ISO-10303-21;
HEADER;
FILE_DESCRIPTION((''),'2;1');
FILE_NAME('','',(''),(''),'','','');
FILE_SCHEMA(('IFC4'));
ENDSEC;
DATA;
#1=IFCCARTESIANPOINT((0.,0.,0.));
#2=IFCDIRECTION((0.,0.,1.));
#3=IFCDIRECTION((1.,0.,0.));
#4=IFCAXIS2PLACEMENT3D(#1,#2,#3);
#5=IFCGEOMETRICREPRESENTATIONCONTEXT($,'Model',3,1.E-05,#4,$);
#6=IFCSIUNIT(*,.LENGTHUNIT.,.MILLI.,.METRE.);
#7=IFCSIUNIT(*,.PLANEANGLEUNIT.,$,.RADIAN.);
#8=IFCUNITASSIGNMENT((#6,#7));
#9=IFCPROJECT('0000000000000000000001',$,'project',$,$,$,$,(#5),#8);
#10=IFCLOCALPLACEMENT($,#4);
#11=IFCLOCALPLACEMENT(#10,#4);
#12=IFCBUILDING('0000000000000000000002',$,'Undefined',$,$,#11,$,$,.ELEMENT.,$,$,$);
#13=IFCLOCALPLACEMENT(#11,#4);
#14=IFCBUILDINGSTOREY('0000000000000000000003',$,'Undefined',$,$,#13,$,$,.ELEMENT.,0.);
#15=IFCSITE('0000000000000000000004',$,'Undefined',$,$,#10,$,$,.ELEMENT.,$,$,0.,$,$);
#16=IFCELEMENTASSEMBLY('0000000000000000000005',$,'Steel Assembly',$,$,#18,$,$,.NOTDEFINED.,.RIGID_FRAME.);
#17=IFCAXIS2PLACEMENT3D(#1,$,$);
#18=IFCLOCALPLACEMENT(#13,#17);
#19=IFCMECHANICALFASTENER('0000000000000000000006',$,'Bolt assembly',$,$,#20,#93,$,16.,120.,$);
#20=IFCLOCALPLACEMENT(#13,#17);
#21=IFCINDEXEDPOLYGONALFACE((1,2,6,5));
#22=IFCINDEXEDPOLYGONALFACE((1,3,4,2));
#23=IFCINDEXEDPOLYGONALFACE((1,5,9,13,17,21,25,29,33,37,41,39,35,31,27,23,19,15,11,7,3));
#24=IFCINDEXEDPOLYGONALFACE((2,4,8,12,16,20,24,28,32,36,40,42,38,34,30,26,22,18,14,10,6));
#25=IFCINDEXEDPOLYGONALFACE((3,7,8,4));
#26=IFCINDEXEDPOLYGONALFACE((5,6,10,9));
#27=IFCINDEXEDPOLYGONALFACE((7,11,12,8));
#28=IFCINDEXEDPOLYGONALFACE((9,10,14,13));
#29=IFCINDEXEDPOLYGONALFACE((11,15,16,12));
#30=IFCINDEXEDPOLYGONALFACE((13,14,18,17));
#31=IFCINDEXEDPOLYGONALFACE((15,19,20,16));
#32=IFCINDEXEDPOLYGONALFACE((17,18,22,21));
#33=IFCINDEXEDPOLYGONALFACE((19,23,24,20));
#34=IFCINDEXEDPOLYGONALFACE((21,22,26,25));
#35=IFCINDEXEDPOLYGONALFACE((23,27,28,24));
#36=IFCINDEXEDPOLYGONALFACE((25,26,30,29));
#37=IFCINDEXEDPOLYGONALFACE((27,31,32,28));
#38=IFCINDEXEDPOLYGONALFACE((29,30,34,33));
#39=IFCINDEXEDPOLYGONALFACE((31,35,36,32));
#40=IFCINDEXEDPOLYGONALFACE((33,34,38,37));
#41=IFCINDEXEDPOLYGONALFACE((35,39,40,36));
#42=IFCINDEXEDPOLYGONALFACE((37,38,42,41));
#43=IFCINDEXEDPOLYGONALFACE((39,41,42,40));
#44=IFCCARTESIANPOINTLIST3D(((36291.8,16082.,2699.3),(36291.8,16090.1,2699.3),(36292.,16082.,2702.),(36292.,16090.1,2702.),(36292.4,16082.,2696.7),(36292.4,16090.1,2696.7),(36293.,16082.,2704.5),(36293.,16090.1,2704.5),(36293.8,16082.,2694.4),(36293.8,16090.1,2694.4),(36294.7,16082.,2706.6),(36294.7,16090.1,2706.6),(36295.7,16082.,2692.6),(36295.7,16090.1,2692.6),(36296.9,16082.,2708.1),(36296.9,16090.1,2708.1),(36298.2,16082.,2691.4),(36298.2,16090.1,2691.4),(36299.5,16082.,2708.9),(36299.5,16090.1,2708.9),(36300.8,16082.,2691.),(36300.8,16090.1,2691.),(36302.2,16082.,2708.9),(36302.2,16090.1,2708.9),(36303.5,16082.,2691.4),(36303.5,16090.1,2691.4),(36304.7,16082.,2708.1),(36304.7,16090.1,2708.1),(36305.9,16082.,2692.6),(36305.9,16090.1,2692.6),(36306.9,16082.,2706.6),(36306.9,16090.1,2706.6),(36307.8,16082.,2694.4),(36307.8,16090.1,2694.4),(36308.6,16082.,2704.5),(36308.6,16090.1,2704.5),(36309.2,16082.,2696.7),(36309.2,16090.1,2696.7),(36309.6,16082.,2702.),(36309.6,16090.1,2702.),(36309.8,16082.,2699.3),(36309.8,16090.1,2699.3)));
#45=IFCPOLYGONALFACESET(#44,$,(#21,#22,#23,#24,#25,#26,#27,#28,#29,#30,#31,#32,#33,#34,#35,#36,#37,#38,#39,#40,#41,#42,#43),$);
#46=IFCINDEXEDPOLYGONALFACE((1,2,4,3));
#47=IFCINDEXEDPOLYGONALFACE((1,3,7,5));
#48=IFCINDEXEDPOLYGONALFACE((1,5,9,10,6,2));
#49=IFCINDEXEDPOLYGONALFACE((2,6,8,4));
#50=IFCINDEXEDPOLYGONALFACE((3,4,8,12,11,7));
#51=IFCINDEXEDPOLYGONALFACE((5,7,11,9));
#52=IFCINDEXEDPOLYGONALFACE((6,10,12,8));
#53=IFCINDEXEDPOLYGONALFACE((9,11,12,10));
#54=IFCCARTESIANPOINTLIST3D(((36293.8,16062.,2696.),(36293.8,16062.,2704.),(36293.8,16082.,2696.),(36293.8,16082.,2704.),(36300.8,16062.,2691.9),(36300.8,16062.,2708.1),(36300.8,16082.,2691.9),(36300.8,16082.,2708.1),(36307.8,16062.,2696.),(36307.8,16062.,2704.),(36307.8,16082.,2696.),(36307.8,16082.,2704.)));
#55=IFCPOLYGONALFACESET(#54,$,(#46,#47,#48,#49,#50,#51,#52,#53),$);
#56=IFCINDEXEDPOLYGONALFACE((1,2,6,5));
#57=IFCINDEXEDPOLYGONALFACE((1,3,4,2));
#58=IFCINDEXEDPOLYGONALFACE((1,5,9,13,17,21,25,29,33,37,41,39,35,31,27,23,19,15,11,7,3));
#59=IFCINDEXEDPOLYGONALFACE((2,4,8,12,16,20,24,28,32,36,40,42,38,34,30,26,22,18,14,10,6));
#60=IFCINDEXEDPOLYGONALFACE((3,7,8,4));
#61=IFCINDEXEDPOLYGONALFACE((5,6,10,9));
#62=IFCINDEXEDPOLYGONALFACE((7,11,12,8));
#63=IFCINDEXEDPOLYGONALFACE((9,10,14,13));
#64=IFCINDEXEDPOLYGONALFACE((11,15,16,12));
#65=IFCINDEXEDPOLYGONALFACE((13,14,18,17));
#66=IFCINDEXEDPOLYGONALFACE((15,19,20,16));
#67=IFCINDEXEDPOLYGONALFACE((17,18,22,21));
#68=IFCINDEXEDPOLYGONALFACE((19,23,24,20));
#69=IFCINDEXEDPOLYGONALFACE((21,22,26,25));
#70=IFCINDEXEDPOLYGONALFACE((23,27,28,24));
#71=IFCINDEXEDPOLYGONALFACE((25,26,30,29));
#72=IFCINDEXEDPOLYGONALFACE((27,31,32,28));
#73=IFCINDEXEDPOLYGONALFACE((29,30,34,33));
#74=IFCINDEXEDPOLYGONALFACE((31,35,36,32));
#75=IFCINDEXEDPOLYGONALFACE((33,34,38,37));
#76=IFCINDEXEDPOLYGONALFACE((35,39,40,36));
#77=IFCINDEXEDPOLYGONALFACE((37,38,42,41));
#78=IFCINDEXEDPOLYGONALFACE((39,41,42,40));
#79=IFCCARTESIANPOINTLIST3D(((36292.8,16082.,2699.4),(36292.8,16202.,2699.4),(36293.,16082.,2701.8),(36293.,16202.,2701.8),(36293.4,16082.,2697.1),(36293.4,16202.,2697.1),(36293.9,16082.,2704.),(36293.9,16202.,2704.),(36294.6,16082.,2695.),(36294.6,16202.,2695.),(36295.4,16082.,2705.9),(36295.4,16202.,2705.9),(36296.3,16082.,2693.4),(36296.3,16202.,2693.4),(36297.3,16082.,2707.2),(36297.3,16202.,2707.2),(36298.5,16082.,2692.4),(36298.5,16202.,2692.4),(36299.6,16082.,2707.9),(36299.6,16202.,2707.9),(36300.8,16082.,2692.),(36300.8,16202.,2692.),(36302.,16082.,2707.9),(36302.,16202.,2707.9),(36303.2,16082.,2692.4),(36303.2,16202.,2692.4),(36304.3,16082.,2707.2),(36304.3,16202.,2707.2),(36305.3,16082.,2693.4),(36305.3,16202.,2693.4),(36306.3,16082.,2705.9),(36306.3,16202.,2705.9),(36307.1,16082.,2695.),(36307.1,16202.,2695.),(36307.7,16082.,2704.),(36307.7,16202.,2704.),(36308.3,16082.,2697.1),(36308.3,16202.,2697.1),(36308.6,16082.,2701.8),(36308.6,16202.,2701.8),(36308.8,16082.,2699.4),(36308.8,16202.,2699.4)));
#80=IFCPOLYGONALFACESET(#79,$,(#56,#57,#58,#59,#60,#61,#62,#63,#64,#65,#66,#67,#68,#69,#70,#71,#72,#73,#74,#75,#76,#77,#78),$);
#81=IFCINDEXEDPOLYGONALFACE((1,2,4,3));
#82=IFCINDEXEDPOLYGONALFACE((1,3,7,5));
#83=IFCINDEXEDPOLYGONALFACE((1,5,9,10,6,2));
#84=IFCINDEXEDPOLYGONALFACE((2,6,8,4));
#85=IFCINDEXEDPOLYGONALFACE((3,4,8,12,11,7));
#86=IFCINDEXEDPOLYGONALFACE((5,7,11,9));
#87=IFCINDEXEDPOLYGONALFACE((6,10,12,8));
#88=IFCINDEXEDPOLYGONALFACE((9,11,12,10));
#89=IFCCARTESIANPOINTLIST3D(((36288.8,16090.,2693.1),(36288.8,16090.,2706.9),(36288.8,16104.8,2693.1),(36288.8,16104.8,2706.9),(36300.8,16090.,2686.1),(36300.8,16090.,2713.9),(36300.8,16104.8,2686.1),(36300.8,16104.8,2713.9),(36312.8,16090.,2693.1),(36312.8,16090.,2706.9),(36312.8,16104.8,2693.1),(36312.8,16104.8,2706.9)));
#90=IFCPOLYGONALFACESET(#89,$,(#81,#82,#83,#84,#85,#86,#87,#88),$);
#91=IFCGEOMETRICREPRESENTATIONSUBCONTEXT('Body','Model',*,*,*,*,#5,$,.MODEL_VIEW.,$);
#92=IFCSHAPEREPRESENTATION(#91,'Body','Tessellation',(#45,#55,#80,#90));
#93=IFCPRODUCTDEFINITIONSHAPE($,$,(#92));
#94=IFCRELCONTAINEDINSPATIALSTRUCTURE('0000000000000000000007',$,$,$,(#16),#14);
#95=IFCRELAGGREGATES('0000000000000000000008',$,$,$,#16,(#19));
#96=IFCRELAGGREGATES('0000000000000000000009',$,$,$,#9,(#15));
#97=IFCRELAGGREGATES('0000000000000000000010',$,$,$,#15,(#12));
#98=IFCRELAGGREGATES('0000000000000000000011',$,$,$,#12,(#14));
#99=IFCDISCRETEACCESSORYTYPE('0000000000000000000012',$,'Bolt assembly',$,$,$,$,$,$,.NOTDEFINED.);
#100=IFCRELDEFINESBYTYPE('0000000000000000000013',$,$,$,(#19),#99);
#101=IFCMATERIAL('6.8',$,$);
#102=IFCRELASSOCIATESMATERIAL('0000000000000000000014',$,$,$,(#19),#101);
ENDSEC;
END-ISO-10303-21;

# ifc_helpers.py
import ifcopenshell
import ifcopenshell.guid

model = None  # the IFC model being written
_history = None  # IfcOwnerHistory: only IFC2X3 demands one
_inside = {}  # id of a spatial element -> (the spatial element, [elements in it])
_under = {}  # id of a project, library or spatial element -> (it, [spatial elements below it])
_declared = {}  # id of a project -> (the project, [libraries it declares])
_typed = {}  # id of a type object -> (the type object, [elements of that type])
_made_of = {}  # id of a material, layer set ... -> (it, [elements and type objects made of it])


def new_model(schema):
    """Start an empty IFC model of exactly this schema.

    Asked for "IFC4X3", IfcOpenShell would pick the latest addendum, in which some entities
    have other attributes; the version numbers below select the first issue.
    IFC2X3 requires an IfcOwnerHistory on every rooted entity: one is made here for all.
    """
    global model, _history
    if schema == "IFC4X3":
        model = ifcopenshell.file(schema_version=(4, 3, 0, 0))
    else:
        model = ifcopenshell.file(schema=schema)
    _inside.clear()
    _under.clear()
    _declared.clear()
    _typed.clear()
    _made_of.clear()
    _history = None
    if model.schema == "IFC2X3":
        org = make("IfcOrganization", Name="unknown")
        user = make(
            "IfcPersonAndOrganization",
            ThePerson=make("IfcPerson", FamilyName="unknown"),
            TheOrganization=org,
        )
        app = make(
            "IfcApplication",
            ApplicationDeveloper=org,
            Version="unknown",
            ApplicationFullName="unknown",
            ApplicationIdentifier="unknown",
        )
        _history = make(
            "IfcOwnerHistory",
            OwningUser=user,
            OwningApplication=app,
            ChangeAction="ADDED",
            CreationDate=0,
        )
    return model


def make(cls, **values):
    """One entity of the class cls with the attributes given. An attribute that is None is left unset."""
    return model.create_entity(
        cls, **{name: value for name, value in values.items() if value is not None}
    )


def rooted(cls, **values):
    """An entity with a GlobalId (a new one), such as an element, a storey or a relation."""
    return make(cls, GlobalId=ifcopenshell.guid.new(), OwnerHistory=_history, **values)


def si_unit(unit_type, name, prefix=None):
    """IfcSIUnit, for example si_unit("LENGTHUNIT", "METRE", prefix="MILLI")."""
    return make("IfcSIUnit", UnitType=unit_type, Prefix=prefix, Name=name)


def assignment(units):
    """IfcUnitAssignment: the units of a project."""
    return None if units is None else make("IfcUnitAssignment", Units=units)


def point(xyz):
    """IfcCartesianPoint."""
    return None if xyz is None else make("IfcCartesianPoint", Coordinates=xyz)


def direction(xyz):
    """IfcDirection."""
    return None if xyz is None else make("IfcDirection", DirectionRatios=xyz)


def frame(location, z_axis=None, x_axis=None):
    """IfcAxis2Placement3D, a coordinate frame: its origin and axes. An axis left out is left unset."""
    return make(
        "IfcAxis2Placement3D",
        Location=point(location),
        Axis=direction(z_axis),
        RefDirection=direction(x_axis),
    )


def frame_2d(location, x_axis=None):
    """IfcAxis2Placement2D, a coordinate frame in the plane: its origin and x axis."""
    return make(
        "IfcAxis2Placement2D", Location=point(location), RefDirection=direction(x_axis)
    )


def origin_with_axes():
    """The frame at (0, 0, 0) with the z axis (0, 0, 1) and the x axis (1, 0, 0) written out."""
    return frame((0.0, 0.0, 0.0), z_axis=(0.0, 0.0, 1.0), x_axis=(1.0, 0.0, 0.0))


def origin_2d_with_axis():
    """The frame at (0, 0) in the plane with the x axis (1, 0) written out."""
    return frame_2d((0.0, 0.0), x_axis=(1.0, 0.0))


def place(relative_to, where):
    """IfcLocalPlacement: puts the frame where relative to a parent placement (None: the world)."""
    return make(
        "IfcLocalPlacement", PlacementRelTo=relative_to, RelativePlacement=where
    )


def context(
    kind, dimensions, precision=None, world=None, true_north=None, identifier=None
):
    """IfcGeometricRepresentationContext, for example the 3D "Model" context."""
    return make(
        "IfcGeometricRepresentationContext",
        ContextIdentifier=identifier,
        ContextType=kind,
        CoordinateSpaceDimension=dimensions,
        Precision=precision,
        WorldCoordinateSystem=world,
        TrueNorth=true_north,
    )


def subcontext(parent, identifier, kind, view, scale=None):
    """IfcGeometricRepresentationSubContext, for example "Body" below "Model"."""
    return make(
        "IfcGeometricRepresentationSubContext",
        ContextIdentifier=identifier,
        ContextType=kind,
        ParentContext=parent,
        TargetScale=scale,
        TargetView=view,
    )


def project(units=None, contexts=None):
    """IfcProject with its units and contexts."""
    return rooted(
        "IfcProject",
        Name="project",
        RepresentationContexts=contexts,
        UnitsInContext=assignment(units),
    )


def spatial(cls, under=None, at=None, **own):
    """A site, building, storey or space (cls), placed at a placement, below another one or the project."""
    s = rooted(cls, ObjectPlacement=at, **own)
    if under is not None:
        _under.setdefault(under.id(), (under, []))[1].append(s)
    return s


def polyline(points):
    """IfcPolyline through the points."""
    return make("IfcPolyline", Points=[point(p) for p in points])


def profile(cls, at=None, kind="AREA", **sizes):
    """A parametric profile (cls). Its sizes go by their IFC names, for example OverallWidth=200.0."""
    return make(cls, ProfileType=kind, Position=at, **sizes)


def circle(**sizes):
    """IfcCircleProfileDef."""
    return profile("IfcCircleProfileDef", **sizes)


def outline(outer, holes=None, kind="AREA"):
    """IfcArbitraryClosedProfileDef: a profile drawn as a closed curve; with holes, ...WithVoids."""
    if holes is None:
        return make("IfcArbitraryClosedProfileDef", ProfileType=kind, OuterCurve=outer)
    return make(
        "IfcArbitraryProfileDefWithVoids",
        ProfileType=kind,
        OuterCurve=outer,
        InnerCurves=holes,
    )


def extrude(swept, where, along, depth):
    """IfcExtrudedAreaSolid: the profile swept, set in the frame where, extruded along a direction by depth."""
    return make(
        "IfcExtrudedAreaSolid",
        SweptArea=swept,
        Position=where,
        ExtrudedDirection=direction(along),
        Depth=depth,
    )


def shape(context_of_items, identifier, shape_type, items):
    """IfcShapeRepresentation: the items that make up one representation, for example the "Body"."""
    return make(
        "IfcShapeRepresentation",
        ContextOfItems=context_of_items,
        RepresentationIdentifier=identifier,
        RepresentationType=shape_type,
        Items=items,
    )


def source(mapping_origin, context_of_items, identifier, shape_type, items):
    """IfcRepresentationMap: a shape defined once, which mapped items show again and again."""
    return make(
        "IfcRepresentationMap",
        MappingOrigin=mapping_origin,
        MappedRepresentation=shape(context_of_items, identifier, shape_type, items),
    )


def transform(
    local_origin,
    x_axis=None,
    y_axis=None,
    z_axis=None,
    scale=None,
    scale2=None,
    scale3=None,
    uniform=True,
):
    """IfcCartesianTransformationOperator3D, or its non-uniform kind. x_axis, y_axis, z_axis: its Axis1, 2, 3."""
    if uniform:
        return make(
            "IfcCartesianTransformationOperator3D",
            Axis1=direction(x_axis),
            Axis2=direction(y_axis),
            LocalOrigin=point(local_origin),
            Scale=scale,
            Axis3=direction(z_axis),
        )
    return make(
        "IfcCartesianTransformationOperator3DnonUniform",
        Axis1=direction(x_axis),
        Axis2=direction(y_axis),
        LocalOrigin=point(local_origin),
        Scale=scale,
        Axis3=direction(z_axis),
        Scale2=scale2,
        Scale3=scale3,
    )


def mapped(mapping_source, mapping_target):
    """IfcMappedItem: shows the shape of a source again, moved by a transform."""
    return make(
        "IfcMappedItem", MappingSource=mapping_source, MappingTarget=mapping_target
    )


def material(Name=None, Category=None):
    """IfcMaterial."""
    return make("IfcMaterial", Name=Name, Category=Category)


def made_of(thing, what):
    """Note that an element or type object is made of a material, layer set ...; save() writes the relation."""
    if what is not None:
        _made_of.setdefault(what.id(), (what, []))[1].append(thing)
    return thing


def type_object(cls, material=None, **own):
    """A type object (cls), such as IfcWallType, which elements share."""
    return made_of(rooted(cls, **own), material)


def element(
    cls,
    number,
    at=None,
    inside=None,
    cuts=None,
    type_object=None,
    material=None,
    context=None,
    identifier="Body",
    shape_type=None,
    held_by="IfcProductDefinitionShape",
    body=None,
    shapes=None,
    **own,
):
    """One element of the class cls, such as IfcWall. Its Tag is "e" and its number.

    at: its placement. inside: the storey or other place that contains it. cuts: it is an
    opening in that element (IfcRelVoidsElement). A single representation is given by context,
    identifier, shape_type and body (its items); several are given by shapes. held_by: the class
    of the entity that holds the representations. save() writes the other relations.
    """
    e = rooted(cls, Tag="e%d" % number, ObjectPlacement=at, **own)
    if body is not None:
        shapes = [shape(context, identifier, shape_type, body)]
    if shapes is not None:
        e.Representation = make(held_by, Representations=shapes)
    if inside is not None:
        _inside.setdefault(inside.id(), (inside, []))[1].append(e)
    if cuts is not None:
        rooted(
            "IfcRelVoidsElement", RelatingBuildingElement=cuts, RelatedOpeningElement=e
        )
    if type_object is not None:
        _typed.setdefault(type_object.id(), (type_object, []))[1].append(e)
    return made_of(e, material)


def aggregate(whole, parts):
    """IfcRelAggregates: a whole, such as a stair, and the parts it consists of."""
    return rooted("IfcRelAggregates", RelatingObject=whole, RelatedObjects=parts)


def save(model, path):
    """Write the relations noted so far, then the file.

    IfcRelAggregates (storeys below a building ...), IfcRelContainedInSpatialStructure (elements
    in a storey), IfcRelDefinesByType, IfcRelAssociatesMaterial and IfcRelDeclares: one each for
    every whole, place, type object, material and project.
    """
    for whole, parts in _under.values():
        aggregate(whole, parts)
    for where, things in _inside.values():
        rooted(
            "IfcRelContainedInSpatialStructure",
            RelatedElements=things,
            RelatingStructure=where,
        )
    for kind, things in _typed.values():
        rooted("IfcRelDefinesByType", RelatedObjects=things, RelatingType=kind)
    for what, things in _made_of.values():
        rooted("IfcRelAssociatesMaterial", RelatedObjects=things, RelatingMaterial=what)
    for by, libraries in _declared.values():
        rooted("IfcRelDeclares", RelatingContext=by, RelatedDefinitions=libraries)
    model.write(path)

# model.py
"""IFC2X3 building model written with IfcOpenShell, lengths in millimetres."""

from ifc_helpers import new_model, si_unit, frame, origin_with_axes, origin_2d_with_axis, place, context, subcontext, project, spatial, polyline, circle, outline, extrude, source, transform, mapped, material, type_object, element, aggregate, save


model = new_model("IFC2X3")

# Units and contexts
model_context = context("Model", 3, precision=1e-05, world=origin_with_axes())
body_context = subcontext(model_context, "Body", "Model", "MODEL_VIEW")
ifc_project = project(units=[si_unit("LENGTHUNIT", "METRE", prefix="MILLI"), si_unit("PLANEANGLEUNIT", "RADIAN")], contexts=[model_context])

# Site, building, storey
site_placement = place(None, origin_with_axes())
site = spatial("IfcSite", under=ifc_project, at=site_placement, Name="Undefined", CompositionType="ELEMENT", RefElevation=0.0)
building_placement = place(site_placement, origin_with_axes())
building = spatial("IfcBuilding", under=site, at=building_placement, Name="Undefined", CompositionType="ELEMENT")
storey_placement = place(building_placement, origin_with_axes())
storey = spatial("IfcBuildingStorey", under=building, at=storey_placement, Name="Undefined", CompositionType="ELEMENT", Elevation=0.0)

# Element assembly
assembly_1_placement = place(storey_placement, origin_with_axes())
assembly_1 = element("IfcElementAssembly", 1, at=assembly_1_placement, inside=storey, Name="Steel Assembly", AssemblyPlace="NOTDEFINED", PredefinedType="RIGID_FRAME")

# Shared definitions
ifc_material_1 = material(Name="6.8")
discrete_accessory_type_1 = type_object("IfcDiscreteAccessoryType", Name="Bolt assembly")
shared_shape_1 = source(origin_with_axes(), body_context, "Body", "SweptSolid", [
    extrude(circle(Radius=9.0, at=origin_2d_with_axis()), frame((0.0, -8.0, 0.0), z_axis=(0.0, 1.0, 0.0), x_axis=(1.0, 0.0, 0.0)), (0.0, 0.0, 1.0), 8.1),
    extrude(outline(polyline([(8.1, 0.0), (4.0, 7.0), (-4.0, 7.0), (-8.1, 0.0), (-4.0, -7.0), (4.0, -7.0), (8.1, 0.0)])), frame((0.0, -28.0, 0.0), z_axis=(0.0, 1.0, 0.0), x_axis=(1.0, 0.0, 0.0)), (0.0, 0.0, 1.0), 20.0),
    extrude(circle(Radius=8.0, at=origin_2d_with_axis()), frame((0.0, -8.0, 0.0), z_axis=(0.0, 1.0, 0.0), x_axis=(1.0, 0.0, 0.0)), (0.0, 0.0, 1.0), 120.0),
    extrude(outline(polyline([(13.9, 0.0), (6.9, 12.0), (-6.9, 12.0), (-13.9, 0.0), (-6.9, -12.0), (6.9, -12.0), (13.9, 0.0)])), frame((0.0, 0.0, 0.0), z_axis=(0.0, 1.0, 0.0), x_axis=(1.0, 0.0, 0.0)), (0.0, 0.0, 1.0), 14.8),
])

# Mechanical fastener
mechanical_fastener_1_placement = place(assembly_1_placement, frame((36300.8, 16090.0, 2700.0), z_axis=(1.0, 0.0, 0.0), x_axis=(0.0, 0.0, -1.0)))
mechanical_fastener_1 = element("IfcMechanicalFastener", 2, at=mechanical_fastener_1_placement, type_object=discrete_accessory_type_1, material=ifc_material_1, Name="Bolt assembly", NominalDiameter=16.0, NominalLength=120.0, context=body_context, shape_type="MappedRepresentation", body=[
    mapped(shared_shape_1, transform((0.0, 0.0, 0.0))),
])

aggregate(assembly_1, [mechanical_fastener_1])

save(model, "model.ifc")
